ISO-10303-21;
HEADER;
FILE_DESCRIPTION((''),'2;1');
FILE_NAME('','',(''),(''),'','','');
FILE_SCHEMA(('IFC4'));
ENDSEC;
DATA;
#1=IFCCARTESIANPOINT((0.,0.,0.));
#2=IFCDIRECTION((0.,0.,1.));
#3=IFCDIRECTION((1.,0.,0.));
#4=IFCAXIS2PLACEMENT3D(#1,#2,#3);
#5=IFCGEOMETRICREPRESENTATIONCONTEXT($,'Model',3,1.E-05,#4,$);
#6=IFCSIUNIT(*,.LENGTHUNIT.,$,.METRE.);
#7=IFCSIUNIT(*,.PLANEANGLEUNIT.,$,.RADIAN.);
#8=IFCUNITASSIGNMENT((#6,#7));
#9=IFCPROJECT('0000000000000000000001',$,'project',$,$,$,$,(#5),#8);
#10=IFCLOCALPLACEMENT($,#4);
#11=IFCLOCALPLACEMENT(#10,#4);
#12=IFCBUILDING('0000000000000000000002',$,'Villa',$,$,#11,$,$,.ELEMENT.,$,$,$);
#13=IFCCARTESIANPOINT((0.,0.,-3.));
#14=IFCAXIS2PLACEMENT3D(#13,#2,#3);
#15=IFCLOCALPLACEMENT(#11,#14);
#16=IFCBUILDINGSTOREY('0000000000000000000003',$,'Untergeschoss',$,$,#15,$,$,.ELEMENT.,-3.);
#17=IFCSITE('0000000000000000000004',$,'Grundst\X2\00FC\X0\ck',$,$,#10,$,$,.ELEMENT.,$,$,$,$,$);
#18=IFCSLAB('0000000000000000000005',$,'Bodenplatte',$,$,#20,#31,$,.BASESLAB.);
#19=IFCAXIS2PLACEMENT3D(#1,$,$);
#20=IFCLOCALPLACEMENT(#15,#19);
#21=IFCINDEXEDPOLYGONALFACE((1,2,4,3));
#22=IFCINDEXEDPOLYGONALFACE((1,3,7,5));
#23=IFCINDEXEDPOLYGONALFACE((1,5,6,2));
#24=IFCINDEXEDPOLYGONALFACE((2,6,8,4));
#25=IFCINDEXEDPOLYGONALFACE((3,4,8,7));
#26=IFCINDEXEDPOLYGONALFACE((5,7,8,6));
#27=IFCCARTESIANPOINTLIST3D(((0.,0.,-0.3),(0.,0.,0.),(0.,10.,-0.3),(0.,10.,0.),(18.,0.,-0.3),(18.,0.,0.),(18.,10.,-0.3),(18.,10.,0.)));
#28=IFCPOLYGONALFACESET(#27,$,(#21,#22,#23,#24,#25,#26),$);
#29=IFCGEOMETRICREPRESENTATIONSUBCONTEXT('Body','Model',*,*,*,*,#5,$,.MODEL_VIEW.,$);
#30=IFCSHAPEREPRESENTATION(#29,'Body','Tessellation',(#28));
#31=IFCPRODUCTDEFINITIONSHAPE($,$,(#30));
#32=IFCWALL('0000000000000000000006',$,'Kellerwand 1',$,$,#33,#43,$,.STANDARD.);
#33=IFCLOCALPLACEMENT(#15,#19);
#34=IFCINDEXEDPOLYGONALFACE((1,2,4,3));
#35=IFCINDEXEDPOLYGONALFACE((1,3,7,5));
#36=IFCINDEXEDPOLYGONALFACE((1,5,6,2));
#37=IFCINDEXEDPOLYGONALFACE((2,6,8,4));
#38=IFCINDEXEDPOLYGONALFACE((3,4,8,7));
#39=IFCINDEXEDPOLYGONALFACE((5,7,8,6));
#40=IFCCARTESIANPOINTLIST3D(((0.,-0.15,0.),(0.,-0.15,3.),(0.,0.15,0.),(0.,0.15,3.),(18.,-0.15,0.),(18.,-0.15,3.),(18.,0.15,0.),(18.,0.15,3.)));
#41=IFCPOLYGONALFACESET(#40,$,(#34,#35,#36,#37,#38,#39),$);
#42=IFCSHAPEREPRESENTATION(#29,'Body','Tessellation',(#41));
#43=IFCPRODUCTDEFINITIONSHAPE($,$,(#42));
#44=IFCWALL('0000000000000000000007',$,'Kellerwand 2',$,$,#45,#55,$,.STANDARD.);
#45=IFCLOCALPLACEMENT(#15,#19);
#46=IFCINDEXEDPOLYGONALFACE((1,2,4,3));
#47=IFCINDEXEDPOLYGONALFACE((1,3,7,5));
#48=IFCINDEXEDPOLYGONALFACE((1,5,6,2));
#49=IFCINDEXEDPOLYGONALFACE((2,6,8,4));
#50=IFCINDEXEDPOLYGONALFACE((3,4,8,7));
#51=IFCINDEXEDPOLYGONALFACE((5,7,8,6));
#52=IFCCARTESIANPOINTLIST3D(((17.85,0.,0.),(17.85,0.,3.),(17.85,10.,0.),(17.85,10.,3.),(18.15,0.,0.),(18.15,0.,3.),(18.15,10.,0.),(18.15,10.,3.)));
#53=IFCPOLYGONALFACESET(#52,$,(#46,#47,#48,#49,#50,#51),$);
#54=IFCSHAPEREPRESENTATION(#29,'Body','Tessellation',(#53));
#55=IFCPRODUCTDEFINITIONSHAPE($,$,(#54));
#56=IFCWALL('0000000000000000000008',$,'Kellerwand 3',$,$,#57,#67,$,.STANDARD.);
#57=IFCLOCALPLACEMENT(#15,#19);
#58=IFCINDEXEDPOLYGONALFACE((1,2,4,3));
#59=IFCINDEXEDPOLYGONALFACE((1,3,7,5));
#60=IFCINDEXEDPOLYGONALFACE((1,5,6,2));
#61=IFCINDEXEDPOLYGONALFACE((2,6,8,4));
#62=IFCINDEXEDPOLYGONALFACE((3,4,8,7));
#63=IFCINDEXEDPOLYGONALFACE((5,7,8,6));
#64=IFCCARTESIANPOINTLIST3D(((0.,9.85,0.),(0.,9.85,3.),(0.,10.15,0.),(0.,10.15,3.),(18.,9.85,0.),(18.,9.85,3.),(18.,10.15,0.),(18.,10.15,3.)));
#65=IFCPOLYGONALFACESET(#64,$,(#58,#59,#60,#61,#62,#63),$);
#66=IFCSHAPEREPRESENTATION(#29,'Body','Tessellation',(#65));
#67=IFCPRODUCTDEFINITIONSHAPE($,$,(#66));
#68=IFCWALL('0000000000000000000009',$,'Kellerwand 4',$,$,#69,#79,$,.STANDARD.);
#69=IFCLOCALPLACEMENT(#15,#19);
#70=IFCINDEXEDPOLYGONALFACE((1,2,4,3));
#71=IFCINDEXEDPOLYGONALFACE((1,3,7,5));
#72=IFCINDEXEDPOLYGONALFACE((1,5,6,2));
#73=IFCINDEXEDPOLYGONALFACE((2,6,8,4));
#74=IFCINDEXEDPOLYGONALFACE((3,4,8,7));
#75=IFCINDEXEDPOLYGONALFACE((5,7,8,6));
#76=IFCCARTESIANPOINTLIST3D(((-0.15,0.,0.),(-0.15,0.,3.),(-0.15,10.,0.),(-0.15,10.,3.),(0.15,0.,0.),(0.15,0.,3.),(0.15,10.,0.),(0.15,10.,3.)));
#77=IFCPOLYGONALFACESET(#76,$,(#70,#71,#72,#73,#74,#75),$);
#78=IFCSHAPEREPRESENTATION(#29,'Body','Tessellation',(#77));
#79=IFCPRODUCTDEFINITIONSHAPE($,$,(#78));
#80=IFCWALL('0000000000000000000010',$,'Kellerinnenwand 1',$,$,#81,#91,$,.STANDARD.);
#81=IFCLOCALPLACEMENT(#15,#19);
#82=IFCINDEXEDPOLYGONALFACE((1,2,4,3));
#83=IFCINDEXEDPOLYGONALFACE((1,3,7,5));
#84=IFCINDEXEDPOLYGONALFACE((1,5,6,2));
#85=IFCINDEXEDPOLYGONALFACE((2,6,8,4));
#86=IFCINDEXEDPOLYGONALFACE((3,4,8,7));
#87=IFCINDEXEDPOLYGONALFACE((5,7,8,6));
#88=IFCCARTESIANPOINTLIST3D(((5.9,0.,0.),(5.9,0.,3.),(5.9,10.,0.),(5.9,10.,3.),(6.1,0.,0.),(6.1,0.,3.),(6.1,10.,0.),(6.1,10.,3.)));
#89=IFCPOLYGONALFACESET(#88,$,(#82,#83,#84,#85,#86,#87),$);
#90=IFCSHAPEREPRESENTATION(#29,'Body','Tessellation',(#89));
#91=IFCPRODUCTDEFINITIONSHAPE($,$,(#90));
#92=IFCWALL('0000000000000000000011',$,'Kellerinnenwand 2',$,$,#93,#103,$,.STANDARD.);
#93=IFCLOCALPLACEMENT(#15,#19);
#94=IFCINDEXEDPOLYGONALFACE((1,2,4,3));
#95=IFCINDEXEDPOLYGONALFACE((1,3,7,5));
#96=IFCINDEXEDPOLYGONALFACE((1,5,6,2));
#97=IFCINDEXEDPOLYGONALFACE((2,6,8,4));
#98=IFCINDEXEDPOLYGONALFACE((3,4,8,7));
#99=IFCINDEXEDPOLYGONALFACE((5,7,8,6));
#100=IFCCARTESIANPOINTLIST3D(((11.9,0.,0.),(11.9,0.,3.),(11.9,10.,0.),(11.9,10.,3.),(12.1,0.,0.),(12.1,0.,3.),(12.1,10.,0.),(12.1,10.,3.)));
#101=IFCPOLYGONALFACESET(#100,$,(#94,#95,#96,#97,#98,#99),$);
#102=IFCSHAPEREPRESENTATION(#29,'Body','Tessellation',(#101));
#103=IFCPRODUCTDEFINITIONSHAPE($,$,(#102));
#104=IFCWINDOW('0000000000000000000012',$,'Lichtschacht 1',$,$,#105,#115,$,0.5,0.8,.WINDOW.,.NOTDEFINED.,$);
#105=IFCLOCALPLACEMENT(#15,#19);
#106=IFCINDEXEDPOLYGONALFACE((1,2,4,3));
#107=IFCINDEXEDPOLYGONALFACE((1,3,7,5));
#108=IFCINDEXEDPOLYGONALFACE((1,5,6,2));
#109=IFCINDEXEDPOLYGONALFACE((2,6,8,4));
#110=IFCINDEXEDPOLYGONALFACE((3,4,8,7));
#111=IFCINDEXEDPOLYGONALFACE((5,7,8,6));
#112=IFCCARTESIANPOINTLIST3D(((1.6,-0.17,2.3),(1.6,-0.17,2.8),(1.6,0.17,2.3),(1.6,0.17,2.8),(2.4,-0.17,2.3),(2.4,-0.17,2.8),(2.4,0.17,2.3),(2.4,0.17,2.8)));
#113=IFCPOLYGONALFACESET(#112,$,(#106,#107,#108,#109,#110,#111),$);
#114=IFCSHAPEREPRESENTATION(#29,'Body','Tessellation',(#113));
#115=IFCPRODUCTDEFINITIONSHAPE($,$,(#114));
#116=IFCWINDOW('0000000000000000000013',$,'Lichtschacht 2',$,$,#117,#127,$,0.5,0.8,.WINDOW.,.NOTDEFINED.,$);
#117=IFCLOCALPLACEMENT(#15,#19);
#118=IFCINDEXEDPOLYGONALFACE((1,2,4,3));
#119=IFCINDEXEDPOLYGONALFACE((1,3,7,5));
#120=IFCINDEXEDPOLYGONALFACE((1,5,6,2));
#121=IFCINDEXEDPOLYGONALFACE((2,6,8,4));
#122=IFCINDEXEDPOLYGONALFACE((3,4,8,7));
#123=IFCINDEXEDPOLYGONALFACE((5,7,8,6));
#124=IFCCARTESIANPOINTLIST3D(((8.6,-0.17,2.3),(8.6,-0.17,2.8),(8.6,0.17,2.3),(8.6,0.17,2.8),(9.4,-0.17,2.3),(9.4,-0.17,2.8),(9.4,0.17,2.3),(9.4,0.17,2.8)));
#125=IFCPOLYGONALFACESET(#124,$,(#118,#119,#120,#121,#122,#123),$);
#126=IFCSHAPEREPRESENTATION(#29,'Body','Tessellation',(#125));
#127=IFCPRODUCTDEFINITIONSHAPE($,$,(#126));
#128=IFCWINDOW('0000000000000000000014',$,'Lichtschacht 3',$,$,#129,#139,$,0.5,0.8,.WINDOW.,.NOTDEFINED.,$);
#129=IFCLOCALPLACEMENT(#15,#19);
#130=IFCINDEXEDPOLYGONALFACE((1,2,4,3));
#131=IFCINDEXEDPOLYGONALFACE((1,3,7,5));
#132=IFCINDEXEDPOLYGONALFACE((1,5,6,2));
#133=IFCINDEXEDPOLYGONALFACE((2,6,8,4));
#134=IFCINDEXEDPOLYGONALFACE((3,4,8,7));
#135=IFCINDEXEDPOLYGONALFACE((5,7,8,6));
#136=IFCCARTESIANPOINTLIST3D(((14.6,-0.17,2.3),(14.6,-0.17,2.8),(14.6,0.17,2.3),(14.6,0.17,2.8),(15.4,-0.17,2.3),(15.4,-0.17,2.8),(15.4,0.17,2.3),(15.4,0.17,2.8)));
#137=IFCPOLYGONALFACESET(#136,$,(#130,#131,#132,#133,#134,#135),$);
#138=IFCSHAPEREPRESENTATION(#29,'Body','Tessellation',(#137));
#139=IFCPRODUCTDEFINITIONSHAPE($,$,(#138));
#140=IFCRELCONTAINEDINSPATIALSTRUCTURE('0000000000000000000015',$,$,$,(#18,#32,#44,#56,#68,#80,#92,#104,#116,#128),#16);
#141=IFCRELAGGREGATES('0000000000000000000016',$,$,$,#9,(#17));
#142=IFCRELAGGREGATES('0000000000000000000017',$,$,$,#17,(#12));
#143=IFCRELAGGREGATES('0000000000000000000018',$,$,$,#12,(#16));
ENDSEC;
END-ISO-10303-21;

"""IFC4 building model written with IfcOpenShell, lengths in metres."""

from ifc_helpers import new_model, si_unit, frame, frame_2d, origin_with_axes, origin_2d, place, context, subcontext, project, spatial, polyline, rectangle, outline, extrude, element, save


model = new_model("IFC4")

# Units and contexts
model_context = context("Model", 3, precision=1e-05, world=origin_with_axes())
body_context = subcontext(model_context, "Body", "Model", "MODEL_VIEW")
ifc_project = project(units=[si_unit("LENGTHUNIT", "METRE"), si_unit("PLANEANGLEUNIT", "RADIAN")], contexts=[model_context])

# Site, building, storey
site_placement = place(None, origin_with_axes())
site = spatial("IfcSite", under=ifc_project, at=site_placement, Name="Grundstück", CompositionType="ELEMENT")
building_placement = place(site_placement, origin_with_axes())
building = spatial("IfcBuilding", under=site, at=building_placement, Name="Villa", CompositionType="ELEMENT")
storey_placement = place(building_placement, frame((0.0, 0.0, -3.0), z_axis=(0.0, 0.0, 1.0), x_axis=(1.0, 0.0, 0.0)))
storey = spatial("IfcBuildingStorey", under=building, at=storey_placement, Name="Untergeschoss", CompositionType="ELEMENT", Elevation=-3.0)

# Slab
slab_placement = place(storey_placement, frame((0.0, 0.0, -0.3), z_axis=(0.0, 0.0, 1.0), x_axis=(1.0, 0.0, 0.0)))
element("IfcSlab", 1, at=slab_placement, inside=storey, Name="Bodenplatte", PredefinedType="BASESLAB", context=body_context, shape_type="SweptSolid", body=[
    extrude(outline(polyline([(0.0, 0.0), (18.0, 0.0), (18.0, 10.0), (0.0, 10.0), (0.0, 0.0)])), origin_with_axes(), (0.0, 0.0, 1.0), 0.3),
])

# Walls
wall_1_placement = place(storey_placement, origin_with_axes())
element("IfcWall", 2, at=wall_1_placement, inside=storey, Name="Kellerwand 1", PredefinedType="STANDARD", context=body_context, shape_type="SweptSolid", body=[
    extrude(rectangle(XDim=18.0, YDim=0.3, at=frame_2d((9.0, 0.0))), origin_with_axes(), (0.0, 0.0, 1.0), 3.0),
])
wall_2_placement = place(storey_placement, frame((18.0, 0.0, 0.0), z_axis=(0.0, 0.0, 1.0), x_axis=(0.0, 1.0, 0.0)))
element("IfcWall", 3, at=wall_2_placement, inside=storey, Name="Kellerwand 2", PredefinedType="STANDARD", context=body_context, shape_type="SweptSolid", body=[
    extrude(rectangle(XDim=10.0, YDim=0.3, at=frame_2d((5.0, 0.0))), origin_with_axes(), (0.0, 0.0, 1.0), 3.0),
])
wall_3_placement = place(storey_placement, frame((18.0, 10.0, 0.0), z_axis=(0.0, 0.0, 1.0), x_axis=(-1.0, 0.0, 0.0)))
element("IfcWall", 4, at=wall_3_placement, inside=storey, Name="Kellerwand 3", PredefinedType="STANDARD", context=body_context, shape_type="SweptSolid", body=[
    extrude(rectangle(XDim=18.0, YDim=0.3, at=frame_2d((9.0, 0.0))), origin_with_axes(), (0.0, 0.0, 1.0), 3.0),
])
wall_4_placement = place(storey_placement, frame((0.0, 10.0, 0.0), z_axis=(0.0, 0.0, 1.0), x_axis=(0.0, -1.0, 0.0)))
element("IfcWall", 5, at=wall_4_placement, inside=storey, Name="Kellerwand 4", PredefinedType="STANDARD", context=body_context, shape_type="SweptSolid", body=[
    extrude(rectangle(XDim=10.0, YDim=0.3, at=frame_2d((5.0, 0.0))), origin_with_axes(), (0.0, 0.0, 1.0), 3.0),
])
for number, where, z_axis, x_axis, name in (
    (6, (6.0, 0.0, 0.0), (0.0, 0.0, 1.0), (0.0, 1.0, 0.0), "Kellerinnenwand 1"),
    (7, (12.0, 0.0, 0.0), (0.0, 0.0, 1.0), (0.0, 1.0, 0.0), "Kellerinnenwand 2"),
):
    element("IfcWall", number, at=place(storey_placement, frame(where, z_axis=z_axis, x_axis=x_axis)), inside=storey, Name=name, PredefinedType="STANDARD", context=body_context, shape_type="SweptSolid", body=[
        extrude(rectangle(XDim=10.0, YDim=0.2, at=frame_2d((5.0, 0.0))), origin_with_axes(), (0.0, 0.0, 1.0), 3.0),
    ])

# Windows
for number, where, z_axis, x_axis, name in (
    (8, (2.0, 0.0, 2.3), (0.0, 0.0, 1.0), (1.0, 0.0, 0.0), "Lichtschacht 1"),
    (9, (9.0, 0.0, 2.3), (0.0, 0.0, 1.0), (1.0, 0.0, 0.0), "Lichtschacht 2"),
    (10, (15.0, 0.0, 2.3), (0.0, 0.0, 1.0), (1.0, 0.0, 0.0), "Lichtschacht 3"),
):
    element("IfcWindow", number, at=place(storey_placement, frame(where, z_axis=z_axis, x_axis=x_axis)), inside=storey, Name=name, OverallHeight=0.5, OverallWidth=0.8, PartitioningType="NOTDEFINED", PredefinedType="WINDOW", context=body_context, shape_type="SweptSolid", body=[
        extrude(rectangle(XDim=0.8, YDim=0.34, at=origin_2d()), origin_with_axes(), (0.0, 0.0, 1.0), 0.5),
    ])

save(model, "model.ifc")
